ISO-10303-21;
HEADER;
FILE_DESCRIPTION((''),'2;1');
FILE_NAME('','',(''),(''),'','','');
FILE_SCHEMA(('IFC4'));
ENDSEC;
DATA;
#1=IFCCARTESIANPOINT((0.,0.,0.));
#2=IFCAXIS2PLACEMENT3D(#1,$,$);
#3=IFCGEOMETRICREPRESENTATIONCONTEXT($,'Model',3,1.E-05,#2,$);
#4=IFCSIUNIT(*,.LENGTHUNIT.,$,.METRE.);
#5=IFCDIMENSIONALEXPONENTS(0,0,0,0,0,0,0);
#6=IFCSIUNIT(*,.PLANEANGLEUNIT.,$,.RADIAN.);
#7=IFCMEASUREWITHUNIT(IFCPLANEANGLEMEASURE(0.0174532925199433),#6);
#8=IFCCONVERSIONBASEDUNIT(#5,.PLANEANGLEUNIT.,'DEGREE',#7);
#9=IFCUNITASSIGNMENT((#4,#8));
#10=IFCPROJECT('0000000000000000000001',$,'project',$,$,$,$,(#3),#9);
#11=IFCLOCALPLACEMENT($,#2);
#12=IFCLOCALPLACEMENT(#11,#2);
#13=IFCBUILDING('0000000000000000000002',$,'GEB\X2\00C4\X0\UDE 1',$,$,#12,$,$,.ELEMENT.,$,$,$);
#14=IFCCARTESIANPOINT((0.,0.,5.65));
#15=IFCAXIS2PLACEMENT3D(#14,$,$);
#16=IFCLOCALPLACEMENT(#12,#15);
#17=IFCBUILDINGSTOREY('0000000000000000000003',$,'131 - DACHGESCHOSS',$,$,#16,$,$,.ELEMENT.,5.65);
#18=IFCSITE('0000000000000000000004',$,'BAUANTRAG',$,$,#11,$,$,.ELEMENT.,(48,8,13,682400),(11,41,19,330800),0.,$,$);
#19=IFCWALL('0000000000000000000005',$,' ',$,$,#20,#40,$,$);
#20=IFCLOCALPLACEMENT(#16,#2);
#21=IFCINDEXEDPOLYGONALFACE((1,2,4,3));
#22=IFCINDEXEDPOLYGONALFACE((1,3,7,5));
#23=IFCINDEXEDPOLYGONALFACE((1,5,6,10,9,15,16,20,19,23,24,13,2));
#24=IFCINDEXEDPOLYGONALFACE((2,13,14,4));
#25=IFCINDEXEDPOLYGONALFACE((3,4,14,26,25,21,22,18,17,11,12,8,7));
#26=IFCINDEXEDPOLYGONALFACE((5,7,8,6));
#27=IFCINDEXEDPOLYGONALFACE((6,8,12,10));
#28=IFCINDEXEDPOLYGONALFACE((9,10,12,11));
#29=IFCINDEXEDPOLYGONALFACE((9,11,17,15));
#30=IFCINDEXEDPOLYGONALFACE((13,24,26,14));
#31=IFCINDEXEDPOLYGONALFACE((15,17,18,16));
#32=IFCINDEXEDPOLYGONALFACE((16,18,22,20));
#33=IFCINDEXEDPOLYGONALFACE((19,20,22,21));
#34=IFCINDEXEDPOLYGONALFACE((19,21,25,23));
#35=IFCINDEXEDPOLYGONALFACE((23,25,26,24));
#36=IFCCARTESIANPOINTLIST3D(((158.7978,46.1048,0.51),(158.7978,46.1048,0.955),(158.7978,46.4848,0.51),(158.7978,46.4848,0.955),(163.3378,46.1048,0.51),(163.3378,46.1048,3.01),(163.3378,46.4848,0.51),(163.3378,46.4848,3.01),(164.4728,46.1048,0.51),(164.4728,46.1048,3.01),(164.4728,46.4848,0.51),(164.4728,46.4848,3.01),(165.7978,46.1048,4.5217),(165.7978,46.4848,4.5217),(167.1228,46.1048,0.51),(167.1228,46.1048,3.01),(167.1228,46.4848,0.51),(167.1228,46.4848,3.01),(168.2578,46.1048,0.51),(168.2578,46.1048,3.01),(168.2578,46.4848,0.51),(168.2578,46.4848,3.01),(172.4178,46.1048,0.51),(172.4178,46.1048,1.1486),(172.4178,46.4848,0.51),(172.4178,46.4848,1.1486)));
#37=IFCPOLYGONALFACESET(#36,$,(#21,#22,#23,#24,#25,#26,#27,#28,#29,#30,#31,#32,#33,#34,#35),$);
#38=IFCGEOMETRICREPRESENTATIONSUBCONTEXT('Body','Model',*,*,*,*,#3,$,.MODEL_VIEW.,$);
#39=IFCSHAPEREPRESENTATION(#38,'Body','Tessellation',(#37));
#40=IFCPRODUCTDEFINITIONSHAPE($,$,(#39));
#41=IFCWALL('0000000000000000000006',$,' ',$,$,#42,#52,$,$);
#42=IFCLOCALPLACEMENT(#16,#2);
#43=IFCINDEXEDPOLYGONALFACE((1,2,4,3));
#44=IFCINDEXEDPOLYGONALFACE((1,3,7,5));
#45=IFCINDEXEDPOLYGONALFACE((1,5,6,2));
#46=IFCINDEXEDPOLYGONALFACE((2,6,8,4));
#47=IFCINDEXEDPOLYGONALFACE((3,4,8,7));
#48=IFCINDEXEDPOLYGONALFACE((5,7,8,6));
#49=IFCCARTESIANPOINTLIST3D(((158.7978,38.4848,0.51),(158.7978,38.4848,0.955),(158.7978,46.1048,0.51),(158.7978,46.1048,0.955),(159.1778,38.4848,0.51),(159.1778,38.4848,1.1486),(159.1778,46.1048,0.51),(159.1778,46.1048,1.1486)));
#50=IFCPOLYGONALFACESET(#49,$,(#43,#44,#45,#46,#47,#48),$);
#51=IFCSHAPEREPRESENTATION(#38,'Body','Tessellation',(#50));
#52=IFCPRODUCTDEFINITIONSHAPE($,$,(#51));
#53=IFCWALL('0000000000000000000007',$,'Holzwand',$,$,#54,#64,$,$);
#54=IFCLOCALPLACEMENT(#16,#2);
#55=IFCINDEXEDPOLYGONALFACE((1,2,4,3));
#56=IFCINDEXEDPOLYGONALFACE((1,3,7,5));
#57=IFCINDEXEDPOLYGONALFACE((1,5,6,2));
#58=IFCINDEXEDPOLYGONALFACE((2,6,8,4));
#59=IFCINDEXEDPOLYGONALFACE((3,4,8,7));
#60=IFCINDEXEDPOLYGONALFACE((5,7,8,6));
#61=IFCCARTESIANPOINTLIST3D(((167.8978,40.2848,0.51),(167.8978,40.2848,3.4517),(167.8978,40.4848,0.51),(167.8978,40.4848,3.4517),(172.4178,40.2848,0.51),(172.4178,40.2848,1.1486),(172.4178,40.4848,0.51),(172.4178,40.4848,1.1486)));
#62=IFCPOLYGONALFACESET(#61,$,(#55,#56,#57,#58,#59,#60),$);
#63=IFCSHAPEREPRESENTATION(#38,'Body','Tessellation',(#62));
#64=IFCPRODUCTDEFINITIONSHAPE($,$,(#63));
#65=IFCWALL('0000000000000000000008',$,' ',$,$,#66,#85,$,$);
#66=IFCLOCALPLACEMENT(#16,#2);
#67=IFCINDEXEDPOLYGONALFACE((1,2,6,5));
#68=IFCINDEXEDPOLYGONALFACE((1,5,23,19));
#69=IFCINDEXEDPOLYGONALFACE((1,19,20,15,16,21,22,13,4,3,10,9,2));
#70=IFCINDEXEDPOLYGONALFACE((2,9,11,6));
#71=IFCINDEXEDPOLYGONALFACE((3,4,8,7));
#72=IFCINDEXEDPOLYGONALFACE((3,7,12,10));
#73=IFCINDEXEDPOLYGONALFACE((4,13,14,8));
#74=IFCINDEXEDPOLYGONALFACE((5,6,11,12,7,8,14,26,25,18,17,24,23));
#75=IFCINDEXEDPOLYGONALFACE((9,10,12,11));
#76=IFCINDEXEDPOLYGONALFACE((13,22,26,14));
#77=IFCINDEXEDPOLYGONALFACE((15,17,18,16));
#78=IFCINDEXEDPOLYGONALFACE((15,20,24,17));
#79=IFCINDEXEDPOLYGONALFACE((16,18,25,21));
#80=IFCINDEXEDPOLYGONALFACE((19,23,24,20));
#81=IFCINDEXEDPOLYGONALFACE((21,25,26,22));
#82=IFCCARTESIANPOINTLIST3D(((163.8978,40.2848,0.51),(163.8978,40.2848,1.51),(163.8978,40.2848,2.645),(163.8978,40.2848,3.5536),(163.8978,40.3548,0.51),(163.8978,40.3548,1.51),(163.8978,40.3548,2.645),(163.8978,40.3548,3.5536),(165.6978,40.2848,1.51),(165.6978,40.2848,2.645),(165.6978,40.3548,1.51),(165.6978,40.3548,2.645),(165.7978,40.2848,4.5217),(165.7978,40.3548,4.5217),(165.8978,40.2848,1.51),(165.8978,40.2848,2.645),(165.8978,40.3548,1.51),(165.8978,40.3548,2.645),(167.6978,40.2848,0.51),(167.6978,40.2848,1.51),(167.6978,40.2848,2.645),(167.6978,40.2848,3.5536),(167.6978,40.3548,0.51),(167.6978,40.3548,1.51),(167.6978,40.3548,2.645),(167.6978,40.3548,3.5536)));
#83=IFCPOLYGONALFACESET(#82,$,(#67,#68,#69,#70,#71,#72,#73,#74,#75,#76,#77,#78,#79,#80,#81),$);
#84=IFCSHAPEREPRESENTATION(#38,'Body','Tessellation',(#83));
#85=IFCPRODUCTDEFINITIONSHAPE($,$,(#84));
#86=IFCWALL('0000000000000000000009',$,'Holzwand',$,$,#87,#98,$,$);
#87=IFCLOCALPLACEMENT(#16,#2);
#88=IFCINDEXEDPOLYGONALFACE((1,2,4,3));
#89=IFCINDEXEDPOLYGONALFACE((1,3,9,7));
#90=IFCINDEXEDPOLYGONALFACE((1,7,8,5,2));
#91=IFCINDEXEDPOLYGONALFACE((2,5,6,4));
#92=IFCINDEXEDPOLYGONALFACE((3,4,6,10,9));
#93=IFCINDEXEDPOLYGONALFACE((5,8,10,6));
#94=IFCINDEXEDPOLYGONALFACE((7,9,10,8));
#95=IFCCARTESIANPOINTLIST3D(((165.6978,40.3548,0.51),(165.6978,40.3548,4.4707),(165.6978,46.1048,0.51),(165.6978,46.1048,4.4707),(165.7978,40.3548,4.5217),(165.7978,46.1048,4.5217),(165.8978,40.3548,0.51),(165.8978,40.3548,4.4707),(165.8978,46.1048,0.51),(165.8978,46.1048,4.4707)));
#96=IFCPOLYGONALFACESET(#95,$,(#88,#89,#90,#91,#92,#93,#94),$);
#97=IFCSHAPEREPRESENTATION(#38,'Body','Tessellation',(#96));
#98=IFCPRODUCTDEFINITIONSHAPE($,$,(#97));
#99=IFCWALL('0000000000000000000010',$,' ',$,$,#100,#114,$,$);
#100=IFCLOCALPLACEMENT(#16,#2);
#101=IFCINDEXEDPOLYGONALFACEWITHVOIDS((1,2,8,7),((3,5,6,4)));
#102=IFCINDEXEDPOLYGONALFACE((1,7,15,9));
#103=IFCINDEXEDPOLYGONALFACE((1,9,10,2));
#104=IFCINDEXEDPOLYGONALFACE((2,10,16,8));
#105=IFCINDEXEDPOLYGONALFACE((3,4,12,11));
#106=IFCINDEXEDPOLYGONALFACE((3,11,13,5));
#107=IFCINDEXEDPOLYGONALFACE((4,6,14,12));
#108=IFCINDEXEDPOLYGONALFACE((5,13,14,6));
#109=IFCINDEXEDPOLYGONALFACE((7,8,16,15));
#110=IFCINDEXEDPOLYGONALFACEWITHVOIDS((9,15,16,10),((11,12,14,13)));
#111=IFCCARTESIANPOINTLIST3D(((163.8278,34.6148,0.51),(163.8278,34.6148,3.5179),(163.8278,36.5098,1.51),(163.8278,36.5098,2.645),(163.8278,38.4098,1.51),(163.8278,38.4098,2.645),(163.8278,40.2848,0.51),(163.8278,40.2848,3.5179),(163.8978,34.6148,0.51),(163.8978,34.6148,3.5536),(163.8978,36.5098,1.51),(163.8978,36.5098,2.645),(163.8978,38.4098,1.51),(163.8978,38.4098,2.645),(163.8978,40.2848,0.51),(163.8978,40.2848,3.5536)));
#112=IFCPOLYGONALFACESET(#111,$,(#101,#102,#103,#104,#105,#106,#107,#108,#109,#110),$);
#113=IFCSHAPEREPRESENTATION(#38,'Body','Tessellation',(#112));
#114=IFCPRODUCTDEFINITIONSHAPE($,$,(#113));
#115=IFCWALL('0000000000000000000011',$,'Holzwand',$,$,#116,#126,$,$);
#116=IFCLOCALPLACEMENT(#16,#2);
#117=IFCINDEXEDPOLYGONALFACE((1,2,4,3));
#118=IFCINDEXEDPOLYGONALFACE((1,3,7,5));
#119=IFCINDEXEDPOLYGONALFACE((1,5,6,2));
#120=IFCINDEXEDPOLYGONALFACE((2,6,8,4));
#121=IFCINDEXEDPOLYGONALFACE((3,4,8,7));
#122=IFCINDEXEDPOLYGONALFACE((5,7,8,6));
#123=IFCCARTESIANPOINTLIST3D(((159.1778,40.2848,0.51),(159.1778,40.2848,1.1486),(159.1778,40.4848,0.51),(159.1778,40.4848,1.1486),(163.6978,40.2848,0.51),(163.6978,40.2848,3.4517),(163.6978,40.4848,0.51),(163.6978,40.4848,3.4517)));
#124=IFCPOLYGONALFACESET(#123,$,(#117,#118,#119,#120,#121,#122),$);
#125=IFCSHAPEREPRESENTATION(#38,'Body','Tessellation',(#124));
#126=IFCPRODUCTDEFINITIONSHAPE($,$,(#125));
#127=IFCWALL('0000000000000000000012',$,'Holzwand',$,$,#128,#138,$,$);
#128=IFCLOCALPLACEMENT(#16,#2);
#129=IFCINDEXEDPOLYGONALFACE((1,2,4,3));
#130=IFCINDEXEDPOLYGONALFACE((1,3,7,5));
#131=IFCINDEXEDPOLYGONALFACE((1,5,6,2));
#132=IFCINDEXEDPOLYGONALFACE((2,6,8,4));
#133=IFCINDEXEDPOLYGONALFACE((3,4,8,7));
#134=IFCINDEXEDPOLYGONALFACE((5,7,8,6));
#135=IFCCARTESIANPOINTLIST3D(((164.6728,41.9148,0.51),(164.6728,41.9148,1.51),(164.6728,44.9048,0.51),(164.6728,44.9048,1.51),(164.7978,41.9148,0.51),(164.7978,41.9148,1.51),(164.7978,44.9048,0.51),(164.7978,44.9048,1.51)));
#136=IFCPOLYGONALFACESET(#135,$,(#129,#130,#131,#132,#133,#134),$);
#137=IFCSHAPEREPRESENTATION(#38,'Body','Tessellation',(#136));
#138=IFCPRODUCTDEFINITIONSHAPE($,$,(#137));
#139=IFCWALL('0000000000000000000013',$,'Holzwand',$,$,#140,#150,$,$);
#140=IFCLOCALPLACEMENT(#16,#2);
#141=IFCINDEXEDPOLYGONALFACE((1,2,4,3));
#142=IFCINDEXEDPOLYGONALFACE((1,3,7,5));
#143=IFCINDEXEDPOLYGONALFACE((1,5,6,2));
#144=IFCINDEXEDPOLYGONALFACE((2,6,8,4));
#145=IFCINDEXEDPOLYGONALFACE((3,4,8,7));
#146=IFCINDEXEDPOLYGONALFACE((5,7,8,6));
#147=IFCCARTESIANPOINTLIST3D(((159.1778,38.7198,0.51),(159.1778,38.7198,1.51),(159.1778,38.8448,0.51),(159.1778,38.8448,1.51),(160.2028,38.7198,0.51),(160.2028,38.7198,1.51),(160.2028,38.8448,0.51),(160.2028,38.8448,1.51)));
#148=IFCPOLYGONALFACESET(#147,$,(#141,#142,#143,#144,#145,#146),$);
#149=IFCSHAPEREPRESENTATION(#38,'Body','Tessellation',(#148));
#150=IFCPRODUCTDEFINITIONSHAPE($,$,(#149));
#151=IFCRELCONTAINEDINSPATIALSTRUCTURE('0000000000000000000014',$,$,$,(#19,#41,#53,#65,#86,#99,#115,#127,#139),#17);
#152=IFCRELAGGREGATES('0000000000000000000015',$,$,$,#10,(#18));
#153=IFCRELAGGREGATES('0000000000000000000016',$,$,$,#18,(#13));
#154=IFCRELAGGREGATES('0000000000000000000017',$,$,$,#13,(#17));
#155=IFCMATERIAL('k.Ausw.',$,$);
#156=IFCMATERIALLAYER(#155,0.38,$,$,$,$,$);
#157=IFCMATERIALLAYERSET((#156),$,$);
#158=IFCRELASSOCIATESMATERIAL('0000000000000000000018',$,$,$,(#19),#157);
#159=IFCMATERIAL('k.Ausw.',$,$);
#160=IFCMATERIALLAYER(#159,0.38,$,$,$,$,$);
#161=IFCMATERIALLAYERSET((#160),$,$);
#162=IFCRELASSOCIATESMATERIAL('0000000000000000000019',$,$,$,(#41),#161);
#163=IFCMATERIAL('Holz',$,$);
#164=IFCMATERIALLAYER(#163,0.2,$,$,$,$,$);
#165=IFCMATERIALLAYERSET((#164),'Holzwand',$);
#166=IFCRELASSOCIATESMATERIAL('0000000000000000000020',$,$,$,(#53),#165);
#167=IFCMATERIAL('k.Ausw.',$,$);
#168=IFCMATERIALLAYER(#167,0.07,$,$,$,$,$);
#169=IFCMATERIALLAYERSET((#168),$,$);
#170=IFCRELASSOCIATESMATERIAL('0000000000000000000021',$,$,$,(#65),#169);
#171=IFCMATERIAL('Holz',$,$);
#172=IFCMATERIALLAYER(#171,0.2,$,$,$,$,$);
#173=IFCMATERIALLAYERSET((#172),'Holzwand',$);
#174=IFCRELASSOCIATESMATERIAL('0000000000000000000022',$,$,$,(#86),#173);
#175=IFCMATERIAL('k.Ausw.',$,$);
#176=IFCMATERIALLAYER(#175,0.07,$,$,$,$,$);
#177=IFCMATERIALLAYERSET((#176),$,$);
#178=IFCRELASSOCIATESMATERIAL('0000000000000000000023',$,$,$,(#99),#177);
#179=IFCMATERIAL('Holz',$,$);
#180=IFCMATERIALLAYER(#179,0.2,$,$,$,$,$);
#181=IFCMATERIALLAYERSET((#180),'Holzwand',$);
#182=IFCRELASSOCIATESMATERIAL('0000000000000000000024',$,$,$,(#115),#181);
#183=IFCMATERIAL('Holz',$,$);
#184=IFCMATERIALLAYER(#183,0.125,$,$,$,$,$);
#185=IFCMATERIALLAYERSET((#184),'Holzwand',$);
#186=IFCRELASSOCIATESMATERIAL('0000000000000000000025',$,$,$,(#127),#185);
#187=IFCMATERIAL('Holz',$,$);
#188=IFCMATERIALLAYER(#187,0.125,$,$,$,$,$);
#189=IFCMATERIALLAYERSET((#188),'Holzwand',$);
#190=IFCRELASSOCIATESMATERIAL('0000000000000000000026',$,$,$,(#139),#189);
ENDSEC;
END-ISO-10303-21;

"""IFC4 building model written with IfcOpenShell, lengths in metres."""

from ifc_helpers import new_model, entity, si_unit, converted_unit, frame, frame_2d, origin, origin_with_axes, place, context, subcontext, project, spatial, polyline, rectangle, outline, extrude, clip, halfspace, bounded_halfspace, material, layer, layer_set, layer_usage, element, save


model = new_model("IFC4")

# Units and contexts
model_context = context("Model", 3, precision=1e-05, world=origin())
body_context = subcontext(model_context, "Body", "Model", "MODEL_VIEW")
ifc_project = project(units=[si_unit("LENGTHUNIT", "METRE"), converted_unit("PLANEANGLEUNIT", "DEGREE", entity("IfcPlaneAngleMeasure", 0.0174532925199433), si_unit("PLANEANGLEUNIT", "RADIAN"), dimensions=[0, 0, 0, 0, 0, 0, 0])], contexts=[model_context])

# Site, building, storey
site_placement = place(None, origin())
site = spatial("IfcSite", under=ifc_project, at=site_placement, Name="BAUANTRAG", CompositionType="ELEMENT", RefLatitude=(48, 8, 13, 682400), RefLongitude=(11, 41, 19, 330800), RefElevation=0.0)
building_placement = place(site_placement, origin())
building = spatial("IfcBuilding", under=site, at=building_placement, Name="GEBÄUDE 1", CompositionType="ELEMENT")
storey_placement = place(building_placement, frame((0.0, 0.0, 5.65)))
storey = spatial("IfcBuildingStorey", under=building, at=storey_placement, Name="131 - DACHGESCHOSS", CompositionType="ELEMENT", Elevation=5.65)

# Wall, openings
ifc_material_1 = material(Name="k.Ausw.")
ifc_layer_1 = layer(ifc_material_1, 0.38)
ifc_layer_set_1 = layer_set([ifc_layer_1])
ifc_layer_usage_1 = layer_usage(ifc_layer_set_1, "AXIS2", "POSITIVE", 0.0)
wall_1_placement = place(storey_placement, frame((172.4178, 46.4848, 0.51), z_axis=(0.0, 0.0, 1.0), x_axis=(-1.0, 0.0, 0.0)))
wall_1 = element("IfcWall", 1, at=wall_1_placement, inside=storey, material=ifc_layer_usage_1, Name=" ", context=body_context, shape_type="Clipping", body=[
    clip(clip(extrude(rectangle(XDim=13.62, YDim=0.38, at=frame_2d((6.81, 0.19), x_axis=(1.0, 0.0))), origin_with_axes(), (0.0, 0.0, 1.0), 4.0117), bounded_halfspace(frame((10.12, 0.19, 2.2283), z_axis=(-0.45399, 0.0, -0.891007), x_axis=(0.0, -1.0, 0.0)), True, origin_with_axes(), polyline([(6.62, 0.38), (6.62, 0.0), (13.62, 0.0), (13.62, 0.38), (6.62, 0.38)]))), bounded_halfspace(frame((3.31, 0.19, 2.3251), z_axis=(0.45399, 0.0, -0.891007), x_axis=(0.0, -1.0, 0.0)), True, origin_with_axes(), polyline([(0.0, 0.38), (0.0, 0.0), (6.62, 0.0), (6.62, 0.38), (0.0, 0.38)]))),
])
opening_1_placement = place(wall_1_placement, frame((9.08, 0.38, 0.0), z_axis=(0.0, -1.0, 0.0), x_axis=(0.0, 0.0, 1.0)))
element("IfcOpeningElement", 2, at=opening_1_placement, cuts=wall_1, ObjectType="Opening", context=body_context, shape_type="SweptSolid", body=[
    extrude(outline(polyline([(0.0, 1.135), (2.5, 1.135), (2.5, 0.0), (0.0, 0.0), (0.0, 1.135)])), origin_with_axes(), (0.0, 0.0, 1.0), 0.38),
])
opening_2_placement = place(wall_1_placement, frame((5.295, 0.38, 0.0), z_axis=(0.0, -1.0, 0.0), x_axis=(0.0, 0.0, 1.0)))
element("IfcOpeningElement", 3, at=opening_2_placement, cuts=wall_1, ObjectType="Opening", context=body_context, shape_type="SweptSolid", body=[
    extrude(outline(polyline([(0.0, 1.135), (2.5, 1.135), (2.5, 0.0), (0.0, 0.0), (0.0, 1.135)])), origin_with_axes(), (0.0, 0.0, 1.0), 0.38),
])

# Walls
ifc_material_2 = material(Name="k.Ausw.")
ifc_layer_2 = layer(ifc_material_2, 0.38)
ifc_layer_set_2 = layer_set([ifc_layer_2])
ifc_layer_usage_2 = layer_usage(ifc_layer_set_2, "AXIS2", "POSITIVE", 0.0)
wall_2_placement = place(storey_placement, frame((158.7978, 46.1048, 0.51), z_axis=(0.0, 0.0, 1.0), x_axis=(0.0, -1.0, 0.0)))
element("IfcWall", 4, at=wall_2_placement, inside=storey, material=ifc_layer_usage_2, Name=" ", context=body_context, shape_type="Clipping", body=[
    clip(extrude(rectangle(XDim=7.62, YDim=0.38, at=frame_2d((3.81, 0.19), x_axis=(1.0, 0.0))), origin_with_axes(), (0.0, 0.0, 1.0), 0.6386), halfspace(frame((3.81, 0.19, 0.5418), z_axis=(0.0, 0.45399, -0.891007), x_axis=(0.0, -0.891007, -0.45399)), True)),
])
ifc_material_3 = material(Name="Holz")
ifc_layer_3 = layer(ifc_material_3, 0.2)
ifc_layer_set_3 = layer_set([ifc_layer_3], Name="Holzwand")
ifc_layer_usage_3 = layer_usage(ifc_layer_set_3, "AXIS2", "POSITIVE", 0.0)
wall_3_placement = place(storey_placement, frame((172.4178, 40.4848, 0.51), z_axis=(0.0, 0.0, 1.0), x_axis=(-1.0, 0.0, 0.0)))
element("IfcWall", 5, at=wall_3_placement, inside=storey, material=ifc_layer_usage_3, Name="Holzwand", context=body_context, shape_type="Clipping", body=[
    clip(extrude(rectangle(XDim=4.52, YDim=0.2, at=frame_2d((2.26, 0.1), x_axis=(1.0, 0.0))), origin_with_axes(), (0.0, 0.0, 1.0), 2.9417), halfspace(frame((2.26, 0.1, 1.7901), z_axis=(0.45399, 0.0, -0.891007), x_axis=(0.891007, 0.0, 0.45399)), True)),
])

# Wall, openings
ifc_material_4 = material(Name="k.Ausw.")
ifc_layer_4 = layer(ifc_material_4, 0.07)
ifc_layer_set_4 = layer_set([ifc_layer_4])
ifc_layer_usage_4 = layer_usage(ifc_layer_set_4, "AXIS2", "POSITIVE", 0.0)
wall_4_placement = place(storey_placement, frame((167.6978, 40.3548, 0.51), z_axis=(0.0, 0.0, 1.0), x_axis=(-1.0, 0.0, 0.0)))
wall_4 = element("IfcWall", 6, at=wall_4_placement, inside=storey, material=ifc_layer_usage_4, Name=" ", context=body_context, shape_type="Clipping", body=[
    clip(clip(extrude(rectangle(XDim=3.8, YDim=0.07, at=frame_2d((1.9, 0.035), x_axis=(1.0, 0.0))), origin_with_axes(), (0.0, 0.0, 1.0), 4.0117), bounded_halfspace(frame((2.85, 0.035, 3.5276), z_axis=(-0.45399, 0.0, -0.891007), x_axis=(-0.891007, 0.0, 0.45399)), True, origin_with_axes(), polyline([(3.8, 0.07), (1.9, 0.07), (1.9, 0.0), (3.8, 0.0), (3.8, 0.07)]))), bounded_halfspace(frame((0.95, 0.035, 3.5276), z_axis=(0.45399, 0.0, -0.891007), x_axis=(0.891007, 0.0, 0.45399)), True, origin_with_axes(), polyline([(0.0, 0.0), (1.9, 0.0), (1.9, 0.07), (0.0, 0.07), (0.0, 0.0)]))),
])
opening_3_placement = place(wall_4_placement, frame((0.0, 0.0, 1.0), z_axis=(0.0, 1.0, 0.0), x_axis=(0.0, 0.0, 1.0)))
element("IfcOpeningElement", 7, at=opening_3_placement, cuts=wall_4, ObjectType="Opening", context=body_context, shape_type="SweptSolid", body=[
    extrude(outline(polyline([(0.0, 1.8), (1.135, 1.8), (1.135, 0.0), (0.0, 0.0), (0.0, 1.8)])), origin_with_axes(), (0.0, 0.0, 1.0), 0.07),
])
opening_4_placement = place(wall_4_placement, frame((2.0, 0.0, 1.0), z_axis=(0.0, 1.0, 0.0), x_axis=(0.0, 0.0, 1.0)))
element("IfcOpeningElement", 8, at=opening_4_placement, cuts=wall_4, ObjectType="Opening", context=body_context, shape_type="SweptSolid", body=[
    extrude(outline(polyline([(0.0, 1.8), (1.135, 1.8), (1.135, 0.0), (0.0, 0.0), (0.0, 1.8)])), origin_with_axes(), (0.0, 0.0, 1.0), 0.07),
])

# Wall
ifc_material_5 = material(Name="Holz")
ifc_layer_5 = layer(ifc_material_5, 0.2)
ifc_layer_set_5 = layer_set([ifc_layer_5], Name="Holzwand")
ifc_layer_usage_5 = layer_usage(ifc_layer_set_5, "AXIS2", "POSITIVE", 0.0)
wall_5_placement = place(storey_placement, frame((165.6978, 46.1048, 0.51), z_axis=(0.0, 0.0, 1.0), x_axis=(0.0, -1.0, 0.0)))
element("IfcWall", 9, at=wall_5_placement, inside=storey, material=ifc_layer_usage_5, Name="Holzwand", context=body_context, shape_type="Clipping", body=[
    clip(clip(extrude(rectangle(XDim=5.75, YDim=0.2, at=frame_2d((2.875, 0.1), x_axis=(1.0, 0.0))), origin_with_axes(), (0.0, 0.0, 1.0), 4.0117), bounded_halfspace(frame((2.875, 0.05, 3.9862), z_axis=(0.0, 0.45399, -0.891007), x_axis=(0.0, 0.891007, 0.45399)), True, origin_with_axes(), polyline([(5.75, 0.0), (5.75, 0.1), (0.0, 0.1), (0.0, 0.0), (5.75, 0.0)]))), bounded_halfspace(frame((2.875, 0.15, 3.9862), z_axis=(0.0, -0.45399, -0.891007), x_axis=(0.0, -0.891007, 0.45399)), True, origin_with_axes(), polyline([(0.0, 0.2), (0.0, 0.1), (5.75, 0.1), (5.75, 0.2), (0.0, 0.2)]))),
])

# Wall, opening
ifc_material_6 = material(Name="k.Ausw.")
ifc_layer_6 = layer(ifc_material_6, 0.07)
ifc_layer_set_6 = layer_set([ifc_layer_6])
ifc_layer_usage_6 = layer_usage(ifc_layer_set_6, "AXIS2", "POSITIVE", 0.0)
wall_6_placement = place(storey_placement, frame((163.8278, 40.2848, 0.51), z_axis=(0.0, 0.0, 1.0), x_axis=(0.0, -1.0, 0.0)))
wall_6 = element("IfcWall", 10, at=wall_6_placement, inside=storey, material=ifc_layer_usage_6, Name=" ", context=body_context, shape_type="Clipping", body=[
    clip(extrude(rectangle(XDim=5.67, YDim=0.07, at=frame_2d((2.835, 0.035), x_axis=(1.0, 0.0))), origin_with_axes(), (0.0, 0.0, 1.0), 3.0436), halfspace(frame((2.835, 0.035, 3.0257), z_axis=(0.0, 0.45399, -0.891007), x_axis=(1.0, 0.0, 0.0)), True)),
])
opening_5_placement = place(wall_6_placement, frame((3.775, 0.07, 1.0), z_axis=(0.0, -1.0, 0.0), x_axis=(0.0, 0.0, 1.0)))
element("IfcOpeningElement", 11, at=opening_5_placement, cuts=wall_6, ObjectType="Opening", context=body_context, shape_type="SweptSolid", body=[
    extrude(outline(polyline([(0.0, 1.9), (1.135, 1.9), (1.135, 0.0), (0.0, 0.0), (0.0, 1.9)])), origin_with_axes(), (0.0, 0.0, 1.0), 0.07),
])

# Walls
ifc_material_7 = material(Name="Holz")
ifc_layer_7 = layer(ifc_material_7, 0.2)
ifc_layer_set_7 = layer_set([ifc_layer_7], Name="Holzwand")
ifc_layer_usage_7 = layer_usage(ifc_layer_set_7, "AXIS2", "POSITIVE", 0.0)
wall_7_placement = place(storey_placement, frame((163.6978, 40.4848, 0.51), z_axis=(0.0, 0.0, 1.0), x_axis=(-1.0, 0.0, 0.0)))
element("IfcWall", 12, at=wall_7_placement, inside=storey, material=ifc_layer_usage_7, Name="Holzwand", context=body_context, shape_type="Clipping", body=[
    clip(extrude(rectangle(XDim=4.52, YDim=0.2, at=frame_2d((2.26, 0.1), x_axis=(1.0, 0.0))), origin_with_axes(), (0.0, 0.0, 1.0), 2.9417), halfspace(frame((2.26, 0.1, 1.7901), z_axis=(-0.45399, 0.0, -0.891007), x_axis=(0.891007, 0.0, -0.45399)), True)),
])
ifc_material_8 = material(Name="Holz")
ifc_layer_8 = layer(ifc_material_8, 0.125)
ifc_layer_set_8 = layer_set([ifc_layer_8], Name="Holzwand")
ifc_layer_usage_8 = layer_usage(ifc_layer_set_8, "AXIS2", "POSITIVE", 0.0)
wall_8_placement = place(storey_placement, frame((164.7978, 41.9148, 0.51), z_axis=(0.0, 0.0, 1.0), x_axis=(0.0, 1.0, 0.0)))
element("IfcWall", 13, at=wall_8_placement, inside=storey, material=ifc_layer_usage_8, Name="Holzwand", context=body_context, shape_type="SweptSolid", body=[
    extrude(rectangle(XDim=2.99, YDim=0.125, at=frame_2d((1.495, 0.0625), x_axis=(1.0, 0.0))), origin_with_axes(), (0.0, 0.0, 1.0), 1.0),
])
ifc_material_9 = material(Name="Holz")
ifc_layer_9 = layer(ifc_material_9, 0.125)
ifc_layer_set_9 = layer_set([ifc_layer_9], Name="Holzwand")
ifc_layer_usage_9 = layer_usage(ifc_layer_set_9, "AXIS2", "POSITIVE", 0.0)
wall_9_placement = place(storey_placement, frame((160.2028, 38.8448, 0.51), z_axis=(0.0, 0.0, 1.0), x_axis=(-1.0, 0.0, 0.0)))
element("IfcWall", 14, at=wall_9_placement, inside=storey, material=ifc_layer_usage_9, Name="Holzwand", context=body_context, shape_type="SweptSolid", body=[
    extrude(rectangle(XDim=1.025, YDim=0.125, at=frame_2d((0.5125, 0.0625), x_axis=(1.0, 0.0))), origin_with_axes(), (0.0, 0.0, 1.0), 1.0),
])

save(model, "model.ifc")
